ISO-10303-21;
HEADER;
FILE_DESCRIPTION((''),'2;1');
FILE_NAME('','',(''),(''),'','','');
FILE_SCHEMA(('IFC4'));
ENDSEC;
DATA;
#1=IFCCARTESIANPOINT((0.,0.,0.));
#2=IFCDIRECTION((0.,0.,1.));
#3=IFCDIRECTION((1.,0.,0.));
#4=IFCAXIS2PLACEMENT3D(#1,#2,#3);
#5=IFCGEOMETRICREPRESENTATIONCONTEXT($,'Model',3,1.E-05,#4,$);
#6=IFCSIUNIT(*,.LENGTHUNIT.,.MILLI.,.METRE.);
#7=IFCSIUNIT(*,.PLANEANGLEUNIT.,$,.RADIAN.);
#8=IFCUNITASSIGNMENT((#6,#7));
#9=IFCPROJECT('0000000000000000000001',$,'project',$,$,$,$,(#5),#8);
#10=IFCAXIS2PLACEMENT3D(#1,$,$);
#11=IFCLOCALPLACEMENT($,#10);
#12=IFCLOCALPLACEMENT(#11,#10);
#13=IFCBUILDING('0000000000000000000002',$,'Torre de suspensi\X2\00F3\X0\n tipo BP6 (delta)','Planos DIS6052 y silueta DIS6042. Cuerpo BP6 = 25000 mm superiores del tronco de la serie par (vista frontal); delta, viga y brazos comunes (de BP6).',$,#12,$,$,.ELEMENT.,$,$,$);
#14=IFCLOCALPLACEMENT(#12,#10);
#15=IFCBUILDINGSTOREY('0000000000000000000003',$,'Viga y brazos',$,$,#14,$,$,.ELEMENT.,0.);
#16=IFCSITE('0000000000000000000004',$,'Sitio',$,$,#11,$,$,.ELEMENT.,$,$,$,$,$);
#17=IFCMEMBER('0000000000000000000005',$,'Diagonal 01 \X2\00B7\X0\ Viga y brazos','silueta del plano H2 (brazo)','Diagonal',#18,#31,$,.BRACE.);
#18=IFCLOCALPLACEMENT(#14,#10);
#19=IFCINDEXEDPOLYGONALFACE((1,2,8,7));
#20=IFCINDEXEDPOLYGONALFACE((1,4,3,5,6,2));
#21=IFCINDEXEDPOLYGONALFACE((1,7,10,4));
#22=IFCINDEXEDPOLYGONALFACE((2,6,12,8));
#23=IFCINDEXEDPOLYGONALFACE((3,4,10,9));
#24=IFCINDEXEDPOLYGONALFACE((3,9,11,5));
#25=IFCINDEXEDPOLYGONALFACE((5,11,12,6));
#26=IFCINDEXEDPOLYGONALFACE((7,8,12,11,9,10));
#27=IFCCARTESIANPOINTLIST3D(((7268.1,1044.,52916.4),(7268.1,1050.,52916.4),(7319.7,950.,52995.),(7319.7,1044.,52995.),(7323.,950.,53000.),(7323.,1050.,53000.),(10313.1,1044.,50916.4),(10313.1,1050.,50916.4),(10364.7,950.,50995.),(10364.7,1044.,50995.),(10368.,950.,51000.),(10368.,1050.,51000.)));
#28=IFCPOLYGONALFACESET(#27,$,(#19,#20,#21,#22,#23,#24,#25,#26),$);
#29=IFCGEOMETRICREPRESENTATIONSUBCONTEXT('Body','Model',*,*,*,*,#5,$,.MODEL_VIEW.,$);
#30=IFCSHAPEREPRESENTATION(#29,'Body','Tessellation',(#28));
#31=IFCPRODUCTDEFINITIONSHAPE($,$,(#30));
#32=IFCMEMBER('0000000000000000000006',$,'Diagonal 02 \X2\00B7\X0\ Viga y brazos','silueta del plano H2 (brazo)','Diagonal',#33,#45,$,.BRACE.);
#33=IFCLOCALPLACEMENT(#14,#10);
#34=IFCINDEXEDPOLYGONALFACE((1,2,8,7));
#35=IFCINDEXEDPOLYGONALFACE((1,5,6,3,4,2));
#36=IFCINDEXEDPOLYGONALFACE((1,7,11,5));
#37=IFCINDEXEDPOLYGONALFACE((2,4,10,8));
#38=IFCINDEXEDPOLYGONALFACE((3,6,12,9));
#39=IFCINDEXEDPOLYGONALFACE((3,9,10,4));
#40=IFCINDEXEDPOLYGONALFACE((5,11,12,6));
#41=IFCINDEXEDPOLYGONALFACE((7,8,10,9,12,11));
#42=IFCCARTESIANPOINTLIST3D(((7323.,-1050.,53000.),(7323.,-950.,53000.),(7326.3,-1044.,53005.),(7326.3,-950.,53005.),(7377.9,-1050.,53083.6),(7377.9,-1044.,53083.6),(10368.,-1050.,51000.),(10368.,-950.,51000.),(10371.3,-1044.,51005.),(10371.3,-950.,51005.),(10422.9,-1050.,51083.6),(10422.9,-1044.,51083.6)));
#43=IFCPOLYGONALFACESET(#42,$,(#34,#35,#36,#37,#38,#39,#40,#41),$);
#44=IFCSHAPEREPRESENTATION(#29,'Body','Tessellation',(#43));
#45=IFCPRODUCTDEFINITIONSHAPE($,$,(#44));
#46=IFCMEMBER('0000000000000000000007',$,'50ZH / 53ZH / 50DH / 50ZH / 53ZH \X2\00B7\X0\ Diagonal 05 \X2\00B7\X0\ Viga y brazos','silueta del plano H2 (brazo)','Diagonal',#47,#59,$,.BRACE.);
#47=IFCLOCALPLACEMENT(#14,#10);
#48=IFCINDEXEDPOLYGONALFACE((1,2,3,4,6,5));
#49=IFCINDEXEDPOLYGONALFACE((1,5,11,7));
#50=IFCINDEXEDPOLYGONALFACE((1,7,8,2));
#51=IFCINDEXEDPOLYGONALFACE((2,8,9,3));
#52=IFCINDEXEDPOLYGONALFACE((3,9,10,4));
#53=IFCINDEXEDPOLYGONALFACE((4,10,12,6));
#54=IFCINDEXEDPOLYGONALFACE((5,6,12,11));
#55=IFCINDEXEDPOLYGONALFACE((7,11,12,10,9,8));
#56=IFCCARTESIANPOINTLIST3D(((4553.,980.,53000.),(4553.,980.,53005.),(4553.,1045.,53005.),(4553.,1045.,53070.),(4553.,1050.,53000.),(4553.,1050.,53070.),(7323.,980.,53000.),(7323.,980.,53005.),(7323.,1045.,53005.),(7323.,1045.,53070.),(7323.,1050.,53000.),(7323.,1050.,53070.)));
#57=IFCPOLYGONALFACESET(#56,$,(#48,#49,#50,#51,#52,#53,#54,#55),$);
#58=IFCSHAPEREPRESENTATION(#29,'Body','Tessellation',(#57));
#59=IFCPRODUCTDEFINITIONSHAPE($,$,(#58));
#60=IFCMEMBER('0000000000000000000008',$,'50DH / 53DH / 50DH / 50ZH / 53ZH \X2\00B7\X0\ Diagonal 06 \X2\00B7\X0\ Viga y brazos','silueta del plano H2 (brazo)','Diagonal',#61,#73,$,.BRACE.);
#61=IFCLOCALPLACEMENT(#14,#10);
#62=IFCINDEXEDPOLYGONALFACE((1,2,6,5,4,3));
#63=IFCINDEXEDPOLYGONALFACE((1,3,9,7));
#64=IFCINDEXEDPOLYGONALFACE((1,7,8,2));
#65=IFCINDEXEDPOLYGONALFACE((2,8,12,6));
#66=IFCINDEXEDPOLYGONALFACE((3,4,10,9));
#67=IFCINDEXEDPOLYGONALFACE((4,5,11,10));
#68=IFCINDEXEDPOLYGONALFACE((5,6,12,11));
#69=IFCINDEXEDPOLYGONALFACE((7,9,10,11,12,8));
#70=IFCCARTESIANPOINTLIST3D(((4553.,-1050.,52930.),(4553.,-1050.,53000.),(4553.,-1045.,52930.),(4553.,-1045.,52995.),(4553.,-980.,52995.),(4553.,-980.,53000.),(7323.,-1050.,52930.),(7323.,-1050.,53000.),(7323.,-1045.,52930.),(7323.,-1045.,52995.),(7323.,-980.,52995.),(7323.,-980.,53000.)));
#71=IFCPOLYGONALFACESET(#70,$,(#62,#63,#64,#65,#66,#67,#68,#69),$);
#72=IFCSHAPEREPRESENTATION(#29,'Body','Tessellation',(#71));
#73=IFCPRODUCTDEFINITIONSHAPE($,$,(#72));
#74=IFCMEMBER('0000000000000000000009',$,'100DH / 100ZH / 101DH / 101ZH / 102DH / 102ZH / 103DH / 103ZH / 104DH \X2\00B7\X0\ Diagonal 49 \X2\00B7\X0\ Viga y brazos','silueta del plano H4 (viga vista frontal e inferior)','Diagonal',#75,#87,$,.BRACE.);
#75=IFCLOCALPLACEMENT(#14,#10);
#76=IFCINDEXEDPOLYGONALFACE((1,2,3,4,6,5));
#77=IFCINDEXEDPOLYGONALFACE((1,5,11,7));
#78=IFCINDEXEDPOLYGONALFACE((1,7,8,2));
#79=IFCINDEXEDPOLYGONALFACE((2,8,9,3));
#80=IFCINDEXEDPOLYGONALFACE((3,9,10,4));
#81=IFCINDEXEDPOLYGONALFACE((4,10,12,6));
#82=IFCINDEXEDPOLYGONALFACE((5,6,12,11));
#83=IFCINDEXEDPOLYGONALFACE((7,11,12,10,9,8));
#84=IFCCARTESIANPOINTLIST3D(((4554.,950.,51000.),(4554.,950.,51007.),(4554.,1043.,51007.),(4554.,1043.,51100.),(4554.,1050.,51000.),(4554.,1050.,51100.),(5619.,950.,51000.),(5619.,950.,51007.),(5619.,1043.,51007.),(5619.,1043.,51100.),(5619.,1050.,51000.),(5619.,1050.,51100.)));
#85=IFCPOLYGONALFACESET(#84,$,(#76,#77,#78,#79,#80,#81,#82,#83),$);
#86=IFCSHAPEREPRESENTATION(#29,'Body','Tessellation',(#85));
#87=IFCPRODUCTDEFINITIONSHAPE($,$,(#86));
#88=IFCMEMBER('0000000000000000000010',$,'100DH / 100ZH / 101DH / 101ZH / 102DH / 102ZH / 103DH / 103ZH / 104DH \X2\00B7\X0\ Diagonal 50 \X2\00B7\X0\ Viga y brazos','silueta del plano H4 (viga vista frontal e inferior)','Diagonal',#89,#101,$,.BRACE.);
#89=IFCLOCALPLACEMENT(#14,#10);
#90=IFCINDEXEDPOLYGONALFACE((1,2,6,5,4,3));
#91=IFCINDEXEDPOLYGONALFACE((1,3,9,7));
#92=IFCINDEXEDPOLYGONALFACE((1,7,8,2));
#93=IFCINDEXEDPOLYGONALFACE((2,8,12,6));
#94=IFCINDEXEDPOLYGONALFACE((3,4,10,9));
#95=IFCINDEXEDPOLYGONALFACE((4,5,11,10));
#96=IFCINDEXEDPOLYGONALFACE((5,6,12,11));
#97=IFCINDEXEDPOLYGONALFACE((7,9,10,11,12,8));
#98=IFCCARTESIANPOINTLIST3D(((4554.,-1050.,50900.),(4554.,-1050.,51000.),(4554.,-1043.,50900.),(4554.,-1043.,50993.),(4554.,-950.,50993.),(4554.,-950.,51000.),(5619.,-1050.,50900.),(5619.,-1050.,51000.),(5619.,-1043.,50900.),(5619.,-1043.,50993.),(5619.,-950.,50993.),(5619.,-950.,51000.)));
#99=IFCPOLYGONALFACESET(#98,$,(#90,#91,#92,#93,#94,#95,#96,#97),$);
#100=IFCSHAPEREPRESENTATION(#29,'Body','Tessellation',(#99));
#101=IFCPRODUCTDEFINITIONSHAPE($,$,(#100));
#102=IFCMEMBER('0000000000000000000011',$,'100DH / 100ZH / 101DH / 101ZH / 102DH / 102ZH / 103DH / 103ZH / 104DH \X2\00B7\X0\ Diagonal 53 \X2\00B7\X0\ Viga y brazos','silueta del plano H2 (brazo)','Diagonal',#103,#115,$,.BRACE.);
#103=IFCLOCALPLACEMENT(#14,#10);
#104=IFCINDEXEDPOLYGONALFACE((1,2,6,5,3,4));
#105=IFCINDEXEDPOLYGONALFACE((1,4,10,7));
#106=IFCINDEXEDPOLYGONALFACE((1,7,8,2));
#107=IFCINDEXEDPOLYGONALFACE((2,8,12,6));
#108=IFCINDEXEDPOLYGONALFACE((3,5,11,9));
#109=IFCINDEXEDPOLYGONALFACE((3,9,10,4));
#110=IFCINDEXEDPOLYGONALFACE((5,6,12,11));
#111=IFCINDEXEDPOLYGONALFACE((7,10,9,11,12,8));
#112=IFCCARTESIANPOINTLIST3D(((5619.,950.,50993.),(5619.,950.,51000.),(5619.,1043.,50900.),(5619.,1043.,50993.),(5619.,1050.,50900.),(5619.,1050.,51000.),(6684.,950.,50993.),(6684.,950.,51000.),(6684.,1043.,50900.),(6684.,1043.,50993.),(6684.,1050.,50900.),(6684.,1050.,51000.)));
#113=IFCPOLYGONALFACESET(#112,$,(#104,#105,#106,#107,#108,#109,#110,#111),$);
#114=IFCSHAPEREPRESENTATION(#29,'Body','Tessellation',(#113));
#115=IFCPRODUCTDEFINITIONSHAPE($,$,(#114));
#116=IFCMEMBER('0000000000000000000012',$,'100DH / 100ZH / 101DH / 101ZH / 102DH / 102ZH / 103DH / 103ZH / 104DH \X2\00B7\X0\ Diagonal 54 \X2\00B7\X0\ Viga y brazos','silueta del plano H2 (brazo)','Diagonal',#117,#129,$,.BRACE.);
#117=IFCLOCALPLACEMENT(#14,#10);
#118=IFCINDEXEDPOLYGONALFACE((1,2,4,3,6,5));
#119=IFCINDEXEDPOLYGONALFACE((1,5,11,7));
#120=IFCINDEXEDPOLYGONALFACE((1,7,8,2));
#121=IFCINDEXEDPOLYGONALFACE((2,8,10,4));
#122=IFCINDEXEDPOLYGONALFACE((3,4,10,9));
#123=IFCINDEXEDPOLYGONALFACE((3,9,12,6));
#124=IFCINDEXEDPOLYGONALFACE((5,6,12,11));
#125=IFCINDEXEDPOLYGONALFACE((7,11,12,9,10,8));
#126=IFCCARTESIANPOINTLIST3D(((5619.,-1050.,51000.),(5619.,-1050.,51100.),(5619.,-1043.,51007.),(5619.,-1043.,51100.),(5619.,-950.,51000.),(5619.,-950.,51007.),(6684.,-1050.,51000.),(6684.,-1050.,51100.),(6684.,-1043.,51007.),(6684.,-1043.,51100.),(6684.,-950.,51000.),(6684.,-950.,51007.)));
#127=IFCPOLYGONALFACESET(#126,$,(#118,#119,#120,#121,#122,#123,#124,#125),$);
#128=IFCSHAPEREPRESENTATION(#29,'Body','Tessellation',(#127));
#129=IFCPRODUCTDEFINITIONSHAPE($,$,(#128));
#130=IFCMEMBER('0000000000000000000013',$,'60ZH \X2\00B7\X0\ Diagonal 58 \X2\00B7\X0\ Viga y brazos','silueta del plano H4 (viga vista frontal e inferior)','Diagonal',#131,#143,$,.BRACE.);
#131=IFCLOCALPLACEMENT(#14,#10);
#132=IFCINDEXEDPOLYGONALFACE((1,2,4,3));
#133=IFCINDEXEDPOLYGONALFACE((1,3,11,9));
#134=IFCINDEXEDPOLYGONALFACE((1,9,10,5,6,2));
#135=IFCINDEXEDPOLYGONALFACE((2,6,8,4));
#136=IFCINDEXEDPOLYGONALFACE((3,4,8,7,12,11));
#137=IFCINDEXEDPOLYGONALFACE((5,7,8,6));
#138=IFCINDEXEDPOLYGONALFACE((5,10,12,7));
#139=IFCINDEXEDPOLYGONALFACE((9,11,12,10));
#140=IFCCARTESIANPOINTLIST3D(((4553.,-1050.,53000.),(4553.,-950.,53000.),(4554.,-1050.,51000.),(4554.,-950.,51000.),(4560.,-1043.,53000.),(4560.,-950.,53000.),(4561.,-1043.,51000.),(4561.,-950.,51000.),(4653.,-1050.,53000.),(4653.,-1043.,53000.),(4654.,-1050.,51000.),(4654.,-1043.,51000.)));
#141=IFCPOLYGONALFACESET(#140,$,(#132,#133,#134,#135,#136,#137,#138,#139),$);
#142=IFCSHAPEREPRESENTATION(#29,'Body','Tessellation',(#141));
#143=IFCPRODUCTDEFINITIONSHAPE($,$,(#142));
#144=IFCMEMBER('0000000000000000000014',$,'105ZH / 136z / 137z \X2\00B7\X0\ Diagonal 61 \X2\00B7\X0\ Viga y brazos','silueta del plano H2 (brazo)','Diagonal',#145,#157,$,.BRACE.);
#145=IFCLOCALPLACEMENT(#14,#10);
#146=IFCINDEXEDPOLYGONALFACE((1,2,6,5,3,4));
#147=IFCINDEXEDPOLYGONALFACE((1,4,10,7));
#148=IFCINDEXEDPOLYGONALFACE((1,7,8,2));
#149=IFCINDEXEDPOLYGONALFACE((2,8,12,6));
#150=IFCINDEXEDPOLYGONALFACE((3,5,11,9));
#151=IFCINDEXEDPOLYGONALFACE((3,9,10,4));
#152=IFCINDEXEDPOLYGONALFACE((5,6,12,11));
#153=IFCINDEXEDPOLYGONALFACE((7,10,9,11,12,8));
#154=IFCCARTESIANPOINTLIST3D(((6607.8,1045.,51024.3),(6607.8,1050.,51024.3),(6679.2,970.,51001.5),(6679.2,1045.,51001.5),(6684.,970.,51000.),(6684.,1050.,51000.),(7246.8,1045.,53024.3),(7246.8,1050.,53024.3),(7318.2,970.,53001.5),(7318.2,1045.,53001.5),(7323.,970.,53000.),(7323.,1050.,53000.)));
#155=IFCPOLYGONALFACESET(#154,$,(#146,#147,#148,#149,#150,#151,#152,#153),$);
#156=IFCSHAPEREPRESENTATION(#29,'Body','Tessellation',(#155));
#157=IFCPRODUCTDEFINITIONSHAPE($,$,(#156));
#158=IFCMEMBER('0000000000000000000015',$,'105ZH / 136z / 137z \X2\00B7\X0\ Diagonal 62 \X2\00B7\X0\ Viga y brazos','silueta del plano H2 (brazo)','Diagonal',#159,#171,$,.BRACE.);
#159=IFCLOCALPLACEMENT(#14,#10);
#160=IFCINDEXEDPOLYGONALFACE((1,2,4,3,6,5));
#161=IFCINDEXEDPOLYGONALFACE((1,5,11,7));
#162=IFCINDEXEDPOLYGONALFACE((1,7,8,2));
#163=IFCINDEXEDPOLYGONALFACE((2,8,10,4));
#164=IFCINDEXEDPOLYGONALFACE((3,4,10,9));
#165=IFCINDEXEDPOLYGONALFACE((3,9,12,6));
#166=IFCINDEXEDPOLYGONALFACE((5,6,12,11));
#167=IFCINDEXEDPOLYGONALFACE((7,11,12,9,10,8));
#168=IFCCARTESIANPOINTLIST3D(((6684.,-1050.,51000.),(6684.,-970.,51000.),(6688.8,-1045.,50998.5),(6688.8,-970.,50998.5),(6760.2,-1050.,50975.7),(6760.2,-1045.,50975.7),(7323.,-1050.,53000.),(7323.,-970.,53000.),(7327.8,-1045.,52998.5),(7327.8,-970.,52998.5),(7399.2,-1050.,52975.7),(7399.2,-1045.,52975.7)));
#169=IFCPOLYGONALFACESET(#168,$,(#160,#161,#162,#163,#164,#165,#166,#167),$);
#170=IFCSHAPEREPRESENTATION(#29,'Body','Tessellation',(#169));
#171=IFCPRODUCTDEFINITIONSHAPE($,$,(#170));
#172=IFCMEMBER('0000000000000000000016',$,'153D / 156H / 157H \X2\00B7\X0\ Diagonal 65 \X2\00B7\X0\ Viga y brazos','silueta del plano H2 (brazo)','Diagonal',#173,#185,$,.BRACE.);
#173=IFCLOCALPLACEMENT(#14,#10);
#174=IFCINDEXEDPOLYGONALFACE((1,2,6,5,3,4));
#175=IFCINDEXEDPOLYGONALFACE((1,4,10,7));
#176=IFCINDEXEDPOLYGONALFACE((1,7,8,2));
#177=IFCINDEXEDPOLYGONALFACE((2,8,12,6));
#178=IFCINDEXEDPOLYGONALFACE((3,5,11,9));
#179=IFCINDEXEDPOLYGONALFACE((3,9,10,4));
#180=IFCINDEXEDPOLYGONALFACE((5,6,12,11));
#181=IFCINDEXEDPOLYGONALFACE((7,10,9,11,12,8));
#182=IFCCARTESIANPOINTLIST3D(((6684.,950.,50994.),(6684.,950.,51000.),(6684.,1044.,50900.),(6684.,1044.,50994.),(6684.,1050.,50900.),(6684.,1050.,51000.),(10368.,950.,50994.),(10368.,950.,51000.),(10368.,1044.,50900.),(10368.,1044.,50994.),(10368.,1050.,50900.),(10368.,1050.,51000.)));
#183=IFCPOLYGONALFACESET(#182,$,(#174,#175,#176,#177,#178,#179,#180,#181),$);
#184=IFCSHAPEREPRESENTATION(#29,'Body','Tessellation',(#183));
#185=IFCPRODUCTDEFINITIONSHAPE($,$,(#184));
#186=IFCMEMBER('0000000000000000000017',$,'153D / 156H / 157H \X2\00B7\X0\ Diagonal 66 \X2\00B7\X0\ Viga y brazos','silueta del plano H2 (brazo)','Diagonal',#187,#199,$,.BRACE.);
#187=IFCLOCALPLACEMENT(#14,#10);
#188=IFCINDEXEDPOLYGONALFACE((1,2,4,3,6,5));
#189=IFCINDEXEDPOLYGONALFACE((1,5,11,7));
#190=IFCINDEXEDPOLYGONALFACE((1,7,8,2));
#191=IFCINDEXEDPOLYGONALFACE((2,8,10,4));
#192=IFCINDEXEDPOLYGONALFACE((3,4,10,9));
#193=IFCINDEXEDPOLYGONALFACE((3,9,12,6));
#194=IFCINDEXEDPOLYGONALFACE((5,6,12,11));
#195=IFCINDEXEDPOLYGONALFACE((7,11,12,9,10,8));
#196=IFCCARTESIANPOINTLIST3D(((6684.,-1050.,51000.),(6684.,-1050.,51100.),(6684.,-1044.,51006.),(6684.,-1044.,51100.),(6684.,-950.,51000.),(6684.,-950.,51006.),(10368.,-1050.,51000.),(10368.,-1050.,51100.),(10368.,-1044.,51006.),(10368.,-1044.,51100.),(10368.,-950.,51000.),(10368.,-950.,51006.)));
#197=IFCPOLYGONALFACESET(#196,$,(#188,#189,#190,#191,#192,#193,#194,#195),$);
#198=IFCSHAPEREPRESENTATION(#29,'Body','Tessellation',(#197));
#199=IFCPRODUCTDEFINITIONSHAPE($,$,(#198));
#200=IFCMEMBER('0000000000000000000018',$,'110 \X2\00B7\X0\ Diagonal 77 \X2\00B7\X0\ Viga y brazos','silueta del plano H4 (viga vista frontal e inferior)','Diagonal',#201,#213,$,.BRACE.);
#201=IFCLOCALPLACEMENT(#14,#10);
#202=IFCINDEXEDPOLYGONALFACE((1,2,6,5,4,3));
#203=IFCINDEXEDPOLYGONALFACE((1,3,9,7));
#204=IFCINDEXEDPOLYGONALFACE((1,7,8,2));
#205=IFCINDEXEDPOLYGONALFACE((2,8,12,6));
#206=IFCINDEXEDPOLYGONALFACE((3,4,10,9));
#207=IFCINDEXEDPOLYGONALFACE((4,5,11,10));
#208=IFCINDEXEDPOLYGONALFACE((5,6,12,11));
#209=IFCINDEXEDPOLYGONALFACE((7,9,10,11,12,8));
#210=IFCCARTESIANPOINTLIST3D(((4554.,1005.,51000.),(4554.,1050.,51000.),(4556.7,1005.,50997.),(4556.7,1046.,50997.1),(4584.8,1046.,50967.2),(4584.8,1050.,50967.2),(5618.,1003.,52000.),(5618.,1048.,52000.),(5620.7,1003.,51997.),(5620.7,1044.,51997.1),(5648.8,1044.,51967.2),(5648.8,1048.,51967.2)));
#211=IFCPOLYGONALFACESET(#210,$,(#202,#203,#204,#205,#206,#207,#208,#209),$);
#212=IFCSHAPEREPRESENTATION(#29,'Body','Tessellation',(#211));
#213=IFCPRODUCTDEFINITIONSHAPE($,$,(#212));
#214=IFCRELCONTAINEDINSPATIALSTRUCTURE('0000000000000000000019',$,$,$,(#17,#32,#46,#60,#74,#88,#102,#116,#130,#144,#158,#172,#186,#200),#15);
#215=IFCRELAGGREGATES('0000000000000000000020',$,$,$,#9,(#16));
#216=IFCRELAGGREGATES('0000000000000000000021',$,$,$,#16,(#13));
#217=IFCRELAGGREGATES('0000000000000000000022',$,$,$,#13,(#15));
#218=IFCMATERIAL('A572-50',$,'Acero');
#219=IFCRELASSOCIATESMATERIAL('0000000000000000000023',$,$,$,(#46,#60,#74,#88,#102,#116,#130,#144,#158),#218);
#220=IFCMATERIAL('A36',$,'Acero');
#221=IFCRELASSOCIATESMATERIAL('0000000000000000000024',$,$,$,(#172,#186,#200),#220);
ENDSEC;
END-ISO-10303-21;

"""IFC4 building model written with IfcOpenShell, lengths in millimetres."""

from ifc_helpers import new_model, si_unit, frame, frame_2d, origin, origin_with_axes, place, context, subcontext, project, spatial, l_section, extrude, material, element, save


model = new_model("IFC4")

# Units and contexts
model_context = context("Model", 3, precision=1e-05, world=origin_with_axes())
body_context = subcontext(model_context, "Body", "Model", "MODEL_VIEW")
ifc_project = project(units=[si_unit("LENGTHUNIT", "METRE", prefix="MILLI"), si_unit("PLANEANGLEUNIT", "RADIAN")], contexts=[model_context])

# Site, building, storey
site_placement = place(None, origin())
site = spatial("IfcSite", under=ifc_project, at=site_placement, Name="Sitio", CompositionType="ELEMENT")
building_placement = place(site_placement, origin())
building = spatial("IfcBuilding", under=site, at=building_placement, Name="Torre de suspensión tipo BP6 (delta)", Description="Planos DIS6052 y silueta DIS6042. Cuerpo BP6 = 25000 mm superiores del tronco de la serie par (vista frontal); delta, viga y brazos comunes (de BP6).", CompositionType="ELEMENT")
storey_placement = place(building_placement, origin())
storey = spatial("IfcBuildingStorey", under=building, at=storey_placement, Name="Viga y brazos", CompositionType="ELEMENT", Elevation=0.0)

# Members
for number, where, z_axis, x_axis, name in (
    (1, (7323.0, 1050.0, 53000.0), (0.835831, 0.0, -0.548986), (0.0, -1.0, 0.0), "Diagonal 01 · Viga y brazos"),
    (2, (7323.0, -1050.0, 53000.0), (0.835831, 0.0, -0.548986), (0.0, 1.0, 0.0), "Diagonal 02 · Viga y brazos"),
):
    element("IfcMember", number, at=place(storey_placement, frame(where, z_axis=z_axis, x_axis=x_axis)), inside=storey, Name=name, Description="silueta del plano H2 (brazo)", ObjectType="Diagonal", PredefinedType="BRACE", context=body_context, shape_type="SweptSolid", body=[
        extrude(l_section(Depth=100.0, Width=100.0, Thickness=6.0, at=frame_2d((50.0, 50.0))), None, (0.0, 0.0, 1.0), 3643.1),
    ])
ifc_material_1 = material(Name="A572-50", Category="Acero")
for number, where, z_axis, x_axis, name in (
    (3, (7323.0, 1050.0, 53000.0), (-1.0, 0.0, 0.0), (0.0, -1.0, 0.0), "50ZH / 53ZH / 50DH / 50ZH / 53ZH · Diagonal 05 · Viga y brazos"),
    (4, (7323.0, -1050.0, 53000.0), (-1.0, 0.0, 0.0), (0.0, 1.0, 0.0), "50DH / 53DH / 50DH / 50ZH / 53ZH · Diagonal 06 · Viga y brazos"),
):
    element("IfcMember", number, at=place(storey_placement, frame(where, z_axis=z_axis, x_axis=x_axis)), inside=storey, material=ifc_material_1, Name=name, Description="silueta del plano H2 (brazo)", ObjectType="Diagonal", PredefinedType="BRACE", context=body_context, shape_type="SweptSolid", body=[
        extrude(l_section(Depth=70.0, Width=70.0, Thickness=5.0, at=frame_2d((35.0, 35.0))), None, (0.0, 0.0, 1.0), 2770.0),
    ])
for number, where, z_axis, x_axis, name, description in (
    (5, (5619.0, 1050.0, 51000.0), (-1.0, 0.0, 0.0), (0.0, -1.0, 0.0), "100DH / 100ZH / 101DH / 101ZH / 102DH / 102ZH / 103DH / 103ZH / 104DH · Diagonal 49 · Viga y brazos", "silueta del plano H4 (viga vista frontal e inferior)"),
    (6, (5619.0, -1050.0, 51000.0), (-1.0, 0.0, 0.0), (0.0, 1.0, 0.0), "100DH / 100ZH / 101DH / 101ZH / 102DH / 102ZH / 103DH / 103ZH / 104DH · Diagonal 50 · Viga y brazos", "silueta del plano H4 (viga vista frontal e inferior)"),
    (7, (5619.0, 1050.0, 51000.0), (1.0, 0.0, 0.0), (0.0, -1.0, 0.0), "100DH / 100ZH / 101DH / 101ZH / 102DH / 102ZH / 103DH / 103ZH / 104DH · Diagonal 53 · Viga y brazos", "silueta del plano H2 (brazo)"),
    (8, (5619.0, -1050.0, 51000.0), (1.0, 0.0, 0.0), (0.0, 1.0, 0.0), "100DH / 100ZH / 101DH / 101ZH / 102DH / 102ZH / 103DH / 103ZH / 104DH · Diagonal 54 · Viga y brazos", "silueta del plano H2 (brazo)"),
):
    element("IfcMember", number, at=place(storey_placement, frame(where, z_axis=z_axis, x_axis=x_axis)), inside=storey, material=ifc_material_1, Name=name, Description=description, ObjectType="Diagonal", PredefinedType="BRACE", context=body_context, shape_type="SweptSolid", body=[
        extrude(l_section(Depth=100.0, Width=100.0, Thickness=7.0, at=frame_2d((50.0, 50.0))), None, (0.0, 0.0, 1.0), 1065.0),
    ])
member_1_placement = place(storey_placement, frame((4553.0, -1050.0, 53000.0), z_axis=(0.0005, 0.0, -1.0), x_axis=(0.0, 1.0, 0.0)))
element("IfcMember", 9, at=member_1_placement, inside=storey, material=ifc_material_1, Name="60ZH · Diagonal 58 · Viga y brazos", Description="silueta del plano H4 (viga vista frontal e inferior)", ObjectType="Diagonal", PredefinedType="BRACE", context=body_context, shape_type="SweptSolid", body=[
    extrude(l_section(Depth=100.0, Width=100.0, Thickness=7.0, at=frame_2d((50.0, 50.0))), None, (0.0, 0.0, 1.0), 2000.0),
])
for number, where, z_axis, x_axis, name in (
    (10, (7323.0, 1050.0, 53000.0), (-0.304344, 0.0, -0.952562), (0.0, -1.0, 0.0), "105ZH / 136z / 137z · Diagonal 61 · Viga y brazos"),
    (11, (7323.0, -1050.0, 53000.0), (-0.304344, 0.0, -0.952562), (0.0, 1.0, 0.0), "105ZH / 136z / 137z · Diagonal 62 · Viga y brazos"),
):
    element("IfcMember", number, at=place(storey_placement, frame(where, z_axis=z_axis, x_axis=x_axis)), inside=storey, material=ifc_material_1, Name=name, Description="silueta del plano H2 (brazo)", ObjectType="Diagonal", PredefinedType="BRACE", context=body_context, shape_type="SweptSolid", body=[
        extrude(l_section(Depth=80.0, Width=80.0, Thickness=5.0, at=frame_2d((40.0, 40.0))), None, (0.0, 0.0, 1.0), 2099.6),
    ])
ifc_material_2 = material(Name="A36", Category="Acero")
for number, where, z_axis, x_axis, name in (
    (12, (6684.0, 1050.0, 51000.0), (1.0, 0.0, 0.0), (0.0, -1.0, 0.0), "153D / 156H / 157H · Diagonal 65 · Viga y brazos"),
    (13, (6684.0, -1050.0, 51000.0), (1.0, 0.0, 0.0), (0.0, 1.0, 0.0), "153D / 156H / 157H · Diagonal 66 · Viga y brazos"),
):
    element("IfcMember", number, at=place(storey_placement, frame(where, z_axis=z_axis, x_axis=x_axis)), inside=storey, material=ifc_material_2, Name=name, Description="silueta del plano H2 (brazo)", ObjectType="Diagonal", PredefinedType="BRACE", context=body_context, shape_type="SweptSolid", body=[
        extrude(l_section(Depth=100.0, Width=100.0, Thickness=6.0, at=frame_2d((50.0, 50.0))), None, (0.0, 0.0, 1.0), 3684.0),
    ])
for number, where, z_axis, x_axis, name in (
    (14, (4554.0, 1050.0, 51000.0), (0.728682, -0.00137, 0.684851), (-0.000998, -0.999999, -0.000938), "110 · Diagonal 77 · Viga y brazos"),
):
    element("IfcMember", number, at=place(storey_placement, frame(where, z_axis=z_axis, x_axis=x_axis)), inside=storey, material=ifc_material_2, Name=name, Description="silueta del plano H4 (viga vista frontal e inferior)", ObjectType="Diagonal", PredefinedType="BRACE", context=body_context, shape_type="SweptSolid", body=[
        extrude(l_section(Depth=45.0, Width=45.0, Thickness=4.0, at=frame_2d((22.5, 22.5))), None, (0.0, 0.0, 1.0), 1460.2),
    ])

save(model, "model.ifc")
